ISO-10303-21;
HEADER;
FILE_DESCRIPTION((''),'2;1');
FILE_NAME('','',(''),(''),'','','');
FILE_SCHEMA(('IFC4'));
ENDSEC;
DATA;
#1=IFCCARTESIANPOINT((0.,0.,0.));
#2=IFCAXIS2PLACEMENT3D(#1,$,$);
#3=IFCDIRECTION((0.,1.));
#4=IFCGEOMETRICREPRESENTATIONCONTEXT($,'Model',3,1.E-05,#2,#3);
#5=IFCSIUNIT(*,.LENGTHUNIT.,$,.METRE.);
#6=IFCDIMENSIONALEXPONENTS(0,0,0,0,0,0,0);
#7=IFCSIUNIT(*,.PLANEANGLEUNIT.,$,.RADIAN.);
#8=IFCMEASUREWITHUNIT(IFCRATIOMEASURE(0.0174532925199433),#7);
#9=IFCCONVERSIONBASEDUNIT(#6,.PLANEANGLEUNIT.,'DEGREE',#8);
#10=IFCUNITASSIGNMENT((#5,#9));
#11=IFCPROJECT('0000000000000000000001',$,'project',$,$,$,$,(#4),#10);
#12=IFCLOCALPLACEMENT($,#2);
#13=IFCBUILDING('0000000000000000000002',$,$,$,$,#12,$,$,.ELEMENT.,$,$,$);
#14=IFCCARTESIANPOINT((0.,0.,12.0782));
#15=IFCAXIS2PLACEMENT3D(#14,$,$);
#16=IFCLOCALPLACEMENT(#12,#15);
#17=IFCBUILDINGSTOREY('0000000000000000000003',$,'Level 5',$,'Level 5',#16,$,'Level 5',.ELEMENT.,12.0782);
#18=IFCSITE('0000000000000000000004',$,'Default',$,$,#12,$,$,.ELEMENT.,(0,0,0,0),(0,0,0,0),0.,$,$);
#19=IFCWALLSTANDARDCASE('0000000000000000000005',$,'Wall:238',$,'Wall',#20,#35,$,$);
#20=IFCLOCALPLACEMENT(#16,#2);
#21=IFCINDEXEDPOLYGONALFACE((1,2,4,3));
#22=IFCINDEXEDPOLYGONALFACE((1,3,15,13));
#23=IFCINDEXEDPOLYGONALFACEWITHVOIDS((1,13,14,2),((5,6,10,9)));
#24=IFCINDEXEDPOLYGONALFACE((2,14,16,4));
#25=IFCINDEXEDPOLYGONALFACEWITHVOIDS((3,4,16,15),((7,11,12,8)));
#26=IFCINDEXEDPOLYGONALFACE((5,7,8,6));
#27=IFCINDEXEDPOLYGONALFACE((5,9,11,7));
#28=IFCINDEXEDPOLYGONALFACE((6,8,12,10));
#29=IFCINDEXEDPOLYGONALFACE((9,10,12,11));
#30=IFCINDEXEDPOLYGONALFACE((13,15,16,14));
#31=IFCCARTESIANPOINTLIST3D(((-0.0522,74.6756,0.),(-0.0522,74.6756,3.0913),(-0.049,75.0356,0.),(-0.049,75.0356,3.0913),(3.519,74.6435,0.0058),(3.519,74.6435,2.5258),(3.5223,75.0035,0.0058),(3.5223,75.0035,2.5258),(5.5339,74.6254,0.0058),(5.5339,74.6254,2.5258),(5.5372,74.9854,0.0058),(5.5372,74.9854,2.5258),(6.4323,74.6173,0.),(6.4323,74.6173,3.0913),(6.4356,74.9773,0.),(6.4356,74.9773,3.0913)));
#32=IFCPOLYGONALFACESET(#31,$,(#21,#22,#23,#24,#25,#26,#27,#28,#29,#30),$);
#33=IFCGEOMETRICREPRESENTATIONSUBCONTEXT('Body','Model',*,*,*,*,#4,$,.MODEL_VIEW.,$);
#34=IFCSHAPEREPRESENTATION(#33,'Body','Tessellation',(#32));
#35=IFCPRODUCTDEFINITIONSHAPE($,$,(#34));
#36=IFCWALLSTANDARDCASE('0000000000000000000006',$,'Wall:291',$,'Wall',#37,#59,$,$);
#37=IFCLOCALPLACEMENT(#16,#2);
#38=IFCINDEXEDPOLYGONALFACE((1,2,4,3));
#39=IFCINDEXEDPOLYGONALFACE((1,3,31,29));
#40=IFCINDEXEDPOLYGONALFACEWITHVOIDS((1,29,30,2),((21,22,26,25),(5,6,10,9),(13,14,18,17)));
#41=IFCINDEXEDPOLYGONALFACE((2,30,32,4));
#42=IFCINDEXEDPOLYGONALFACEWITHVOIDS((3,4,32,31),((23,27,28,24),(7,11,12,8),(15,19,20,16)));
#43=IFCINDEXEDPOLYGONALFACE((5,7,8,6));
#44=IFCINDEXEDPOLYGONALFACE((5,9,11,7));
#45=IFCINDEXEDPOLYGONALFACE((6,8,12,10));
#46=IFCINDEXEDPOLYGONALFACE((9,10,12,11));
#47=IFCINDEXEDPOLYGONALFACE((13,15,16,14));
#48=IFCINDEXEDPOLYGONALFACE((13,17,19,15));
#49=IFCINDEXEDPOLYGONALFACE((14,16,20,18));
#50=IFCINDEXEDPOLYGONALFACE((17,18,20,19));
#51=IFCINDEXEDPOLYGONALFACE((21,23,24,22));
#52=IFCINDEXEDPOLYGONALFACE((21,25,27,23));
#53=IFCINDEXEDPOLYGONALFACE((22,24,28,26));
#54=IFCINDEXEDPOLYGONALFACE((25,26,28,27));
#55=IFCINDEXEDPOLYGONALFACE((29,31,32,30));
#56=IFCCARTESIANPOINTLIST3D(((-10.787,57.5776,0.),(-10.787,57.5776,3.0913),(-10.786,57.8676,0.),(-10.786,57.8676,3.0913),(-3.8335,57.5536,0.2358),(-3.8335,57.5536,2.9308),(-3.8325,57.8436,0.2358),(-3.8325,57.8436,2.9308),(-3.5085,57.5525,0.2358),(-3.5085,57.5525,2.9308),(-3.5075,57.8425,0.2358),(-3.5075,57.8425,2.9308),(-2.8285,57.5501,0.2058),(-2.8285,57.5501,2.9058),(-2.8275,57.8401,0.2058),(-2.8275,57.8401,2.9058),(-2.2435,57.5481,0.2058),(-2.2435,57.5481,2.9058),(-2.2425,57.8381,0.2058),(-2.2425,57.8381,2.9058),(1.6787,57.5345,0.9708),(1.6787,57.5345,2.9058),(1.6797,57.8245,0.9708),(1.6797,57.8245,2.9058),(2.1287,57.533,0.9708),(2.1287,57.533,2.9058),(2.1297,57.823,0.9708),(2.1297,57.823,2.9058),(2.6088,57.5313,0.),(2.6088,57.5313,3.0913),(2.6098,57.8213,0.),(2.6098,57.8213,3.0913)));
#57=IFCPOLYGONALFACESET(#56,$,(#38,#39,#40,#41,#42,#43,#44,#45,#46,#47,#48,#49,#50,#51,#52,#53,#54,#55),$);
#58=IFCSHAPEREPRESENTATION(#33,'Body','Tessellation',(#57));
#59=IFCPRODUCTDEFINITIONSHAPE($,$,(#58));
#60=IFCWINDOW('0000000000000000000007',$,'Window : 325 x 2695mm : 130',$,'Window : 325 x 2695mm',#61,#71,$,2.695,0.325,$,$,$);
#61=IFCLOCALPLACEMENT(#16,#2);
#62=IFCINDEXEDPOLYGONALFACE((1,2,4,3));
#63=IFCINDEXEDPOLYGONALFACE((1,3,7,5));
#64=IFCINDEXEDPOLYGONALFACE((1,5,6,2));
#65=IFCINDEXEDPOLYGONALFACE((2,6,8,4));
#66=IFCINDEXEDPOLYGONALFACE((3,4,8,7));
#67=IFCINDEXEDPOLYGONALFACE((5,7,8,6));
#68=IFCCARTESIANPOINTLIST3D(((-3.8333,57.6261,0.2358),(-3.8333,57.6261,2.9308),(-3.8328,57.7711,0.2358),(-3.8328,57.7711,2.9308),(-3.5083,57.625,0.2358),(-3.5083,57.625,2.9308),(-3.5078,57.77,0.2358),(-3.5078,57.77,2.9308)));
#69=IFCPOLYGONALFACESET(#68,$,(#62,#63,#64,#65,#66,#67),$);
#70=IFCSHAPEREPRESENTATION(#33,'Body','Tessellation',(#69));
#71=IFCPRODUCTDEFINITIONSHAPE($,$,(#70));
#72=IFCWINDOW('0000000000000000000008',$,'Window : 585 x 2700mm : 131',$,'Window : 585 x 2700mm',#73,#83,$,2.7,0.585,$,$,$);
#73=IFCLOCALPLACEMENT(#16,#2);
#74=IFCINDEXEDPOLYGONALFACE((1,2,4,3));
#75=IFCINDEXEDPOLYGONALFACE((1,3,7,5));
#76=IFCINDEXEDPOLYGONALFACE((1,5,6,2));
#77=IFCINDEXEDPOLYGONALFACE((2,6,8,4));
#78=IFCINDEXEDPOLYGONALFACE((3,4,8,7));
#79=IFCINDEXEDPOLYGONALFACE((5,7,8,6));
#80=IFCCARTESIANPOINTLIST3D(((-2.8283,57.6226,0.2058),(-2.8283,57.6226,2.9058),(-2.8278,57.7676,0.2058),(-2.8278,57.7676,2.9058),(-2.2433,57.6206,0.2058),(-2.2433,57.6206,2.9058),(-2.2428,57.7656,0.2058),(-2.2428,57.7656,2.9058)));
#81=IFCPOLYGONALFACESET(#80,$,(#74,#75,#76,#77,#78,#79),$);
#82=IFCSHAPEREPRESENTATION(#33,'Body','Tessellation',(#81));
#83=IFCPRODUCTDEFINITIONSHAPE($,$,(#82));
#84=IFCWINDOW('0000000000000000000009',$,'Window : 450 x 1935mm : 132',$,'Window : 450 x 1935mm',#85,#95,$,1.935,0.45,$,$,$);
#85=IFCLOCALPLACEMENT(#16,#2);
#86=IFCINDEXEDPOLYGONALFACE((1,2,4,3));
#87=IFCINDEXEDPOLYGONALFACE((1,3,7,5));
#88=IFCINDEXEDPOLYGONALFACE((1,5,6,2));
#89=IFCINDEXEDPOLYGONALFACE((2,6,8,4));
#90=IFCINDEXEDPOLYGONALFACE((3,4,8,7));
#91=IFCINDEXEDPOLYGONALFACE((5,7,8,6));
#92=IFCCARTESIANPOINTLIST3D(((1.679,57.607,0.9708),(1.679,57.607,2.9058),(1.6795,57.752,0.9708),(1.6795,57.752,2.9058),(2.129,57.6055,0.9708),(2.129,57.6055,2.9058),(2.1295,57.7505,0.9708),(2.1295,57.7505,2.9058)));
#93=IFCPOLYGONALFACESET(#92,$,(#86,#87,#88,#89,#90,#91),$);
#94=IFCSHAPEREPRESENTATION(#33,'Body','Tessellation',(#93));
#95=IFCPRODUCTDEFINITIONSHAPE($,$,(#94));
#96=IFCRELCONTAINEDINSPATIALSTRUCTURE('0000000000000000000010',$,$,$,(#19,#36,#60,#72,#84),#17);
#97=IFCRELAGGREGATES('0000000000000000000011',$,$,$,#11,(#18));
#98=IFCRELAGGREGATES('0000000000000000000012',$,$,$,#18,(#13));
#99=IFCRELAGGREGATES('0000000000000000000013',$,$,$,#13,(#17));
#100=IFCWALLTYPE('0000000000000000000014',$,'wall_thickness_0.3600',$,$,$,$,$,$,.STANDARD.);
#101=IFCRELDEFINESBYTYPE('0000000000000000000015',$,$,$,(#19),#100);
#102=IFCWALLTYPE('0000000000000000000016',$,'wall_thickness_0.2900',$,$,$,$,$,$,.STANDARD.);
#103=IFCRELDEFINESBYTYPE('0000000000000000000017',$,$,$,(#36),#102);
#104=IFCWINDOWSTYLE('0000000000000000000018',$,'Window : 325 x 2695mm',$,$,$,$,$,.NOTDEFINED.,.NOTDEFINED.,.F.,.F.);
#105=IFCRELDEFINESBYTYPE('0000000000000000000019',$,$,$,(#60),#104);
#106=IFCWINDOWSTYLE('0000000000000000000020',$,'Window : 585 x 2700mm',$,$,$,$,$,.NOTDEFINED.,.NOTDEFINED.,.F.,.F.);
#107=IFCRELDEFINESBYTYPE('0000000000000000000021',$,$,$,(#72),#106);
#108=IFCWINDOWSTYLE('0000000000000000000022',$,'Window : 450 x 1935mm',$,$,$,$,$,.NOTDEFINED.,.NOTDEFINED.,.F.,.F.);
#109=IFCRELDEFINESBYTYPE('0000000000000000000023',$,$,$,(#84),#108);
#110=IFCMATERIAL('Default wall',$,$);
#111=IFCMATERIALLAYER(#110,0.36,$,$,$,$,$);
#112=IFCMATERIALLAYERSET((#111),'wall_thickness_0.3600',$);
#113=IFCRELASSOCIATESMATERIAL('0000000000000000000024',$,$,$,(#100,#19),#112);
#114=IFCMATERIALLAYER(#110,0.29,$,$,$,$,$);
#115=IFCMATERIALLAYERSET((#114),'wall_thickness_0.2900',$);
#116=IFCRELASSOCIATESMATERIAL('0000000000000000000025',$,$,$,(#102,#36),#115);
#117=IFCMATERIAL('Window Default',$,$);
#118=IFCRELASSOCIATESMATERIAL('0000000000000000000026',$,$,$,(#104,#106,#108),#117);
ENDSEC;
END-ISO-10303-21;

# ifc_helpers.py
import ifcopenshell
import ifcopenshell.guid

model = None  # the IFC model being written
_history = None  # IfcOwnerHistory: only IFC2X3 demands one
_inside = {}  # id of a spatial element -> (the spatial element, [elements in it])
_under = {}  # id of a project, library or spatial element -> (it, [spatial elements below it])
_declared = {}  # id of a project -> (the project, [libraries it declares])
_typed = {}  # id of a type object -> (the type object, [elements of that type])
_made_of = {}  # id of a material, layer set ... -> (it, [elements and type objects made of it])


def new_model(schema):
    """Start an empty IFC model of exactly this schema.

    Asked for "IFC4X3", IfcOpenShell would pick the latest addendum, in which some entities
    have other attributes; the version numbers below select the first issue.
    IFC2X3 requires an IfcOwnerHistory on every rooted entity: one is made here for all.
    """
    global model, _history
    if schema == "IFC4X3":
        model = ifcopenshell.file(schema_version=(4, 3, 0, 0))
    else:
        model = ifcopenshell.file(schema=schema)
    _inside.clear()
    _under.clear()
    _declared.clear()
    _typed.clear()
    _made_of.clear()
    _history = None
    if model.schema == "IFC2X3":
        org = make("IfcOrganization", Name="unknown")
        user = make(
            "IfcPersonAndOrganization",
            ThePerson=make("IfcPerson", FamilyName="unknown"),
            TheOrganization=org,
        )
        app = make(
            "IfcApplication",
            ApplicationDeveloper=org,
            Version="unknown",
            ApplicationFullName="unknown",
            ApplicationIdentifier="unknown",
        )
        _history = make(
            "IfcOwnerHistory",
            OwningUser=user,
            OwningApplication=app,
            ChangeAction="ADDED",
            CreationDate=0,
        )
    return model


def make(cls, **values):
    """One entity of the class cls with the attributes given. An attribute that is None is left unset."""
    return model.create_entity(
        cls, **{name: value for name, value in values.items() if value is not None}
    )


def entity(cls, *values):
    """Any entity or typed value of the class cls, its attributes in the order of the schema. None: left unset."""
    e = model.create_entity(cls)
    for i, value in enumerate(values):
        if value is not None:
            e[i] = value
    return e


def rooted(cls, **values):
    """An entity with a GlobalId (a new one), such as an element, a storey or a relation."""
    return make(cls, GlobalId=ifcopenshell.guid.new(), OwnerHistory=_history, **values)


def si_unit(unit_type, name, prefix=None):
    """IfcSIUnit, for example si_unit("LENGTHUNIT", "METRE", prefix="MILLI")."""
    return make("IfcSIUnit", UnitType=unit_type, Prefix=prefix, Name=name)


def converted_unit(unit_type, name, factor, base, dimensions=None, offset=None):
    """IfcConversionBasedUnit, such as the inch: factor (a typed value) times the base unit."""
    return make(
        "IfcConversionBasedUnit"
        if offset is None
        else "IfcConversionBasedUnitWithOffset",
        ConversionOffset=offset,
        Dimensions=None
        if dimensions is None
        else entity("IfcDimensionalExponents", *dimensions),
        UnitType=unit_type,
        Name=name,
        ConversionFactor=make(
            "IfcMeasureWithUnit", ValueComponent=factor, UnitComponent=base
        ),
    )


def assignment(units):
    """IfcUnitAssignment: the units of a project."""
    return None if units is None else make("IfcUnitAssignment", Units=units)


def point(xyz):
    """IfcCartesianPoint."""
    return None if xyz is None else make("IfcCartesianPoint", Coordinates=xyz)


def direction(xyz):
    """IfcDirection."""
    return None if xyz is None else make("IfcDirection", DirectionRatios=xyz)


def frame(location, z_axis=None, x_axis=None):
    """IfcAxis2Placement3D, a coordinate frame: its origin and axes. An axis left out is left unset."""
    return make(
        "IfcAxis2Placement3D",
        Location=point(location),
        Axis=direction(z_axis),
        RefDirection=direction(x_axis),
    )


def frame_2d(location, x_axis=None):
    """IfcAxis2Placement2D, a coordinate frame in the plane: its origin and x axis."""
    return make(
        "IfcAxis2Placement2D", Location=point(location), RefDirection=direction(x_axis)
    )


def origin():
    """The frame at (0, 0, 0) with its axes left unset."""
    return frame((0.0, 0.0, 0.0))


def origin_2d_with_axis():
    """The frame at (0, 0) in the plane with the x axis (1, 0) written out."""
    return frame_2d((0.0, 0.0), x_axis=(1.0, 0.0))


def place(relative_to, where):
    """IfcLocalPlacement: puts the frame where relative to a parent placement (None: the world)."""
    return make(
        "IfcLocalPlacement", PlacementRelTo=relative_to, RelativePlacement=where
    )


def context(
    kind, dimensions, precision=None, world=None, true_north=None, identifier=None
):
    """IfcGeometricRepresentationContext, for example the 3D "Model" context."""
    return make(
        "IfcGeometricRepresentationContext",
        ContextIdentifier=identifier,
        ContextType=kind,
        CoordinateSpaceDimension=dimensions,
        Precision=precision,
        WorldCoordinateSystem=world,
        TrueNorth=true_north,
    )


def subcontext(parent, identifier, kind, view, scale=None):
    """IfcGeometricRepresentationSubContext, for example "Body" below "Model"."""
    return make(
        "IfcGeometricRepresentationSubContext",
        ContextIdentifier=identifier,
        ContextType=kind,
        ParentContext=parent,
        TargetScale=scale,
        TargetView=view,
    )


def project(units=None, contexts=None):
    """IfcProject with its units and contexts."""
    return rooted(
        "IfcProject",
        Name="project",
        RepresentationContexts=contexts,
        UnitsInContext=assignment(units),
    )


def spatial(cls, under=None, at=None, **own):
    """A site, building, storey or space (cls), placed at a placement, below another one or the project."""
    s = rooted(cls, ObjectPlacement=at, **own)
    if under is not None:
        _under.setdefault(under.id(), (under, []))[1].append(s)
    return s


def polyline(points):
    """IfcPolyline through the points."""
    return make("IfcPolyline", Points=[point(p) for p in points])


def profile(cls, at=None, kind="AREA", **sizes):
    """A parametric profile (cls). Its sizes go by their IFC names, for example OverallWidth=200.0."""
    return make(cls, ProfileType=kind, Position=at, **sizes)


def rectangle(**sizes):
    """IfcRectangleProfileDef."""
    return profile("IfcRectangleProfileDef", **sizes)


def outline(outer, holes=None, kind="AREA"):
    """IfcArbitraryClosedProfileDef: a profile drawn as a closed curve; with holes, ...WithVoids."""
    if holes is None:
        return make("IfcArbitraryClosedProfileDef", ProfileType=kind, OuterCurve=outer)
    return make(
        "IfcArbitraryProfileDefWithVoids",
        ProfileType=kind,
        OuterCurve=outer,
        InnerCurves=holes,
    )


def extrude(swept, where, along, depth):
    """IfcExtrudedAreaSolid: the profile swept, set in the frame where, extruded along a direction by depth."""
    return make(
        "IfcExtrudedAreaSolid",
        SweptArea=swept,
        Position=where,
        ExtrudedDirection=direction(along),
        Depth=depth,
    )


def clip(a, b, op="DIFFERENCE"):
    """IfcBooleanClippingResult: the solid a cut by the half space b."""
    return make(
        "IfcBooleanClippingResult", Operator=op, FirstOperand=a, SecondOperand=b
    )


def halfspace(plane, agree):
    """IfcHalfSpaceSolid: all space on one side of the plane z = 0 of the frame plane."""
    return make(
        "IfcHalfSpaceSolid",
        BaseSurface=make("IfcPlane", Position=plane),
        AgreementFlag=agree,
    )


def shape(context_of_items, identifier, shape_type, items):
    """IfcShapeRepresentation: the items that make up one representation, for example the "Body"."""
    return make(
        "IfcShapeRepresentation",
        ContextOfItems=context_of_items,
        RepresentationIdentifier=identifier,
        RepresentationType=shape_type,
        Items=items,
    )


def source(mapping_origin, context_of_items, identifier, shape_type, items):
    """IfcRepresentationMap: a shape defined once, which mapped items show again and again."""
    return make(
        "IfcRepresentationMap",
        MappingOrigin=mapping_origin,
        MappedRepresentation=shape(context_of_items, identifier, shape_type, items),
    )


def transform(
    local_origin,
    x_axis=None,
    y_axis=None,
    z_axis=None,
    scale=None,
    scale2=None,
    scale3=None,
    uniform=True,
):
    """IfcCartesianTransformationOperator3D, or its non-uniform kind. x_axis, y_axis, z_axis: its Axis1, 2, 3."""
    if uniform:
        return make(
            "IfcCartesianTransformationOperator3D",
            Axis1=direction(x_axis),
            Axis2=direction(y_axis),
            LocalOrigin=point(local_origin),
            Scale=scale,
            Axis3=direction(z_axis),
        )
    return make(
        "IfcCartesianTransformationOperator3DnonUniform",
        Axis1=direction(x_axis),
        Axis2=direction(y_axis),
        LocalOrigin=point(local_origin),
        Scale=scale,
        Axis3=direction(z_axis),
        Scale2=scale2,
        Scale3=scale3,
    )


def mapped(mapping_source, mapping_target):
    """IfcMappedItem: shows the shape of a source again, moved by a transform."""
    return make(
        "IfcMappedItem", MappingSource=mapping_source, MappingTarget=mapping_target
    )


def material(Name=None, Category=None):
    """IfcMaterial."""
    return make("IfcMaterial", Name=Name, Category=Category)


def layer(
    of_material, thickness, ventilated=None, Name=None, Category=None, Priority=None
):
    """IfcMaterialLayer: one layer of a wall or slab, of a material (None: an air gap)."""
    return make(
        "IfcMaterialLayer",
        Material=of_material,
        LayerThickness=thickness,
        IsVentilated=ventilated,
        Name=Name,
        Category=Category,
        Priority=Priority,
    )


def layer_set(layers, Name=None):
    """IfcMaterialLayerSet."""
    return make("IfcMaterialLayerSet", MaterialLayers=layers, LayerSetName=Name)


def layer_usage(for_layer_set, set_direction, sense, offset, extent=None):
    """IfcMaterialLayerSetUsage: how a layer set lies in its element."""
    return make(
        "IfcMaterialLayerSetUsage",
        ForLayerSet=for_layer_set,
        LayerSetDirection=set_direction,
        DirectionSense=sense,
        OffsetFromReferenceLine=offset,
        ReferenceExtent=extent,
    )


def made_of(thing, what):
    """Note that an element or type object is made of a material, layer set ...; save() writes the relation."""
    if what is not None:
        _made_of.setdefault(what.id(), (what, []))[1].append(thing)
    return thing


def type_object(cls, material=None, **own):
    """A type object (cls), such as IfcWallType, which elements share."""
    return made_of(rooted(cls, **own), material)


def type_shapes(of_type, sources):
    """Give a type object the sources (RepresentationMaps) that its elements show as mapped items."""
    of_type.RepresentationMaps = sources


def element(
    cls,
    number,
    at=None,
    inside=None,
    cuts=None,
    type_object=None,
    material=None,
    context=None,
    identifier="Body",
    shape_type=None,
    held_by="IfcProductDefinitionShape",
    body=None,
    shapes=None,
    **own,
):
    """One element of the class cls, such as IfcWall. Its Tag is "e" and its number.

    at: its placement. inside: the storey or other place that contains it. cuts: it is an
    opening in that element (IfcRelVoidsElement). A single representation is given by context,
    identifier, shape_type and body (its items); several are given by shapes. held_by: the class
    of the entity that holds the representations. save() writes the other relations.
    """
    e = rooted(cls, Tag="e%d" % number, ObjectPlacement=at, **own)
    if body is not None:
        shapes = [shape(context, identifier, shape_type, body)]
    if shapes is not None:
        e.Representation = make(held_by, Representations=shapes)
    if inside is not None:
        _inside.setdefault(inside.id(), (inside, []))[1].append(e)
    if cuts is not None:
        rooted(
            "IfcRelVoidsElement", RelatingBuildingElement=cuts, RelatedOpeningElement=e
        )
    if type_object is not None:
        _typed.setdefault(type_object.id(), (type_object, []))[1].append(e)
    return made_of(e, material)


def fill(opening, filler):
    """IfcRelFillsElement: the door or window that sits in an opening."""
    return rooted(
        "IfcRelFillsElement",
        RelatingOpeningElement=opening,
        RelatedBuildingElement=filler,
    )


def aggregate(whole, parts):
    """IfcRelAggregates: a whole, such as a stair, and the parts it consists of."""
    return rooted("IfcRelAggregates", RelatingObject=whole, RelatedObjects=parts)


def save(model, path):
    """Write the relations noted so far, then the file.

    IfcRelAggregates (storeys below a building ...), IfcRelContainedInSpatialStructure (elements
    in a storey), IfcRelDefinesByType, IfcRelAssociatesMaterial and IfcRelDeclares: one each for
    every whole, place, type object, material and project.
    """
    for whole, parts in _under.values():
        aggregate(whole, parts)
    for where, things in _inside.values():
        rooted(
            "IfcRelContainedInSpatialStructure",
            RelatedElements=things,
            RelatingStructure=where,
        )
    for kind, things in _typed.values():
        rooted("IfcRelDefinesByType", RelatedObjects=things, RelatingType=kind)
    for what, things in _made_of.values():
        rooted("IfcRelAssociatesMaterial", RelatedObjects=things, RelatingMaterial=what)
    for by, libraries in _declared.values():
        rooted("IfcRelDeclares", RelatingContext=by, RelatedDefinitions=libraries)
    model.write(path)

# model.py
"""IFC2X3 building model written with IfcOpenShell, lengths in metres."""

from ifc_helpers import new_model, entity, si_unit, converted_unit, direction, frame, frame_2d, origin, origin_2d_with_axis, place, context, subcontext, project, spatial, polyline, rectangle, outline, extrude, clip, halfspace, source, transform, mapped, material, layer, layer_set, layer_usage, type_object, type_shapes, element, fill, save


model = new_model("IFC2X3")

# Units and contexts
model_context = context("Model", 3, precision=1e-05, world=origin(), true_north=direction((0.0, 1.0)))
body_context = subcontext(model_context, "Body", "Model", "MODEL_VIEW")
ifc_project = project(units=[si_unit("LENGTHUNIT", "METRE"), converted_unit("PLANEANGLEUNIT", "DEGREE", entity("IfcRatioMeasure", 0.0174532925199433), si_unit("PLANEANGLEUNIT", "RADIAN"), dimensions=[0, 0, 0, 0, 0, 0, 0])], contexts=[model_context])

# Site, building, storey
placement_1 = place(None, origin())
site = spatial("IfcSite", under=ifc_project, at=placement_1, Name="Default", CompositionType="ELEMENT", RefLatitude=(0, 0, 0, 0), RefLongitude=(0, 0, 0, 0), RefElevation=0.0)
building = spatial("IfcBuilding", under=site, at=placement_1, CompositionType="ELEMENT")
storey_placement = place(placement_1, frame((0.0, 0.0, 12.0782)))
storey = spatial("IfcBuildingStorey", under=building, at=storey_placement, Name="Level 5", ObjectType="Level 5", LongName="Level 5", CompositionType="ELEMENT", Elevation=12.0782)

# Shared definitions
ifc_material_1 = material(Name="Default wall")

# Shared definitions
ifc_layer_1 = layer(ifc_material_1, 0.36)
ifc_layer_set_1 = layer_set([ifc_layer_1], Name="wall_thickness_0.3600")
ifc_layer_usage_1 = layer_usage(ifc_layer_set_1, "AXIS2", "POSITIVE", -0.18)
wall_type_1 = type_object("IfcWallType", Name="wall_thickness_0.3600", PredefinedType="STANDARD", material=ifc_layer_set_1)
ifc_material_2 = material(Name="Window Default")

# Wall, opening
wall_1_placement = place(storey_placement, frame((-0.0506, 74.8556, 0.0), z_axis=(0.0, 0.0, 1.0), x_axis=(0.99996, -0.008993, 0.0)))
wall_1 = element("IfcWallStandardCase", 1, at=wall_1_placement, inside=storey, type_object=wall_type_1, material=ifc_layer_usage_1, Name="Wall:238", ObjectType="Wall", context=body_context, shape_type="Clipping", body=[
    clip(extrude(outline(polyline([(6.4848, -0.18), (6.4848, 0.18), (0.0, 0.18), (0.0, -0.18), (6.4848, -0.18)])), origin(), (0.0, 0.0, 1.0), 3.0913), halfspace(frame((13.6125, 3.7855, 5.7734), z_axis=(-0.003713, 0.39562, 0.918407), x_axis=(-0.999956, -0.009385, 0.0)), False)),
])
opening_1_placement = place(wall_1_placement, frame((3.5714, -0.18, 0.0058)))
element("IfcOpeningElement", 2, at=opening_1_placement, cuts=wall_1, ObjectType="Opening", context=body_context, shape_type="SweptSolid", body=[
    extrude(rectangle(XDim=2.015, YDim=2.52, at=frame_2d((1.26, 1.0075), x_axis=(0.0, 1.0))), frame((0.0, 0.0, 0.0), z_axis=(0.0, 1.0, 0.0), x_axis=(0.0, 0.0, 1.0)), (0.0, 0.0, 1.0), 0.36),
])

# Wall, openings, windows
ifc_layer_2 = layer(ifc_material_1, 0.29)
ifc_layer_set_2 = layer_set([ifc_layer_2], Name="wall_thickness_0.2900")
ifc_layer_usage_2 = layer_usage(ifc_layer_set_2, "AXIS2", "POSITIVE", -0.145)
wall_type_2 = type_object("IfcWallType", Name="wall_thickness_0.2900", PredefinedType="STANDARD", material=ifc_layer_set_2)
wall_2_placement = place(storey_placement, frame((-10.7865, 57.7226, 0.0), z_axis=(0.0, 0.0, 1.0), x_axis=(0.999994, -0.00346, 0.0)))
wall_2 = element("IfcWallStandardCase", 3, at=wall_2_placement, inside=storey, type_object=wall_type_2, material=ifc_layer_usage_2, Name="Wall:291", ObjectType="Wall", context=body_context, shape_type="Clipping", body=[
    clip(extrude(outline(polyline([(13.3959, -0.145), (13.3959, 0.145), (0.0, 0.145), (0.0, -0.145), (13.3959, -0.145)])), origin(), (0.0, 0.0, 1.0), 3.0913), halfspace(frame((-1.9669, 0.0778, 9.0175), z_axis=(-0.002535, -0.391122, 0.920336), x_axis=(0.999989, -0.00469, 0.000761)), False)),
])
opening_2_placement = place(wall_2_placement, frame((6.9535, -0.145, 0.2358)))
opening_2 = element("IfcOpeningElement", 4, at=opening_2_placement, cuts=wall_2, ObjectType="Opening", context=body_context, shape_type="SweptSolid", body=[
    extrude(rectangle(XDim=0.325, YDim=2.695, at=frame_2d((1.3475, 0.1625), x_axis=(0.0, 1.0))), frame((0.0, 0.0, 0.0), z_axis=(0.0, 1.0, 0.0), x_axis=(0.0, 0.0, 1.0)), (0.0, 0.0, 1.0), 0.29),
])
opening_3_placement = place(wall_2_placement, frame((7.9585, -0.145, 0.2058)))
opening_3 = element("IfcOpeningElement", 5, at=opening_3_placement, cuts=wall_2, ObjectType="Opening", context=body_context, shape_type="SweptSolid", body=[
    extrude(rectangle(XDim=0.585, YDim=2.7, at=frame_2d((1.35, 0.2925), x_axis=(0.0, 1.0))), frame((0.0, 0.0, 0.0), z_axis=(0.0, 1.0, 0.0), x_axis=(0.0, 0.0, 1.0)), (0.0, 0.0, 1.0), 0.29),
])
opening_4_placement = place(wall_2_placement, frame((12.4658, -0.145, 0.9708)))
opening_4 = element("IfcOpeningElement", 6, at=opening_4_placement, cuts=wall_2, ObjectType="Opening", context=body_context, shape_type="SweptSolid", body=[
    extrude(rectangle(XDim=0.45, YDim=1.935, at=frame_2d((0.9675, 0.225), x_axis=(0.0, 1.0))), frame((0.0, 0.0, 0.0), z_axis=(0.0, 1.0, 0.0), x_axis=(0.0, 0.0, 1.0)), (0.0, 0.0, 1.0), 0.29),
])
window_style_1 = type_object("IfcWindowStyle", Name="Window : 325 x 2695mm", ConstructionType="NOTDEFINED", OperationType="NOTDEFINED", ParameterTakesPrecedence=False, Sizeable=False, material=ifc_material_2)
shared_shape_1 = source(origin(), body_context, "Body", "SweptSolid", [
    extrude(rectangle(XDim=0.145, YDim=0.325, at=origin_2d_with_axis()), frame((0.1625, 0.145, 0.0), z_axis=(0.0, 0.0, 1.0), x_axis=(0.0, 1.0, 0.0)), (0.0, 0.0, 1.0), 2.695),
])
type_shapes(window_style_1, [shared_shape_1])
window_1_placement = place(opening_2_placement, origin())
window_1 = element("IfcWindow", 7, at=window_1_placement, inside=storey, type_object=window_style_1, Name="Window : 325 x 2695mm : 130", ObjectType="Window : 325 x 2695mm", OverallHeight=2.695, OverallWidth=0.325, context=body_context, shape_type="MappedRepresentation", body=[
    mapped(shared_shape_1, transform((0.0, 0.0, 0.0), scale=1.0)),
])
fill(opening_2, window_1)
window_style_2 = type_object("IfcWindowStyle", Name="Window : 585 x 2700mm", ConstructionType="NOTDEFINED", OperationType="NOTDEFINED", ParameterTakesPrecedence=False, Sizeable=False, material=ifc_material_2)
shared_shape_2 = source(origin(), body_context, "Body", "SweptSolid", [
    extrude(rectangle(XDim=0.145, YDim=0.585, at=origin_2d_with_axis()), frame((0.2925, 0.145, 0.0), z_axis=(0.0, 0.0, 1.0), x_axis=(0.0, 1.0, 0.0)), (0.0, 0.0, 1.0), 2.7),
])
type_shapes(window_style_2, [shared_shape_2])
window_2_placement = place(opening_3_placement, origin())
window_2 = element("IfcWindow", 8, at=window_2_placement, inside=storey, type_object=window_style_2, Name="Window : 585 x 2700mm : 131", ObjectType="Window : 585 x 2700mm", OverallHeight=2.7, OverallWidth=0.585, context=body_context, shape_type="MappedRepresentation", body=[
    mapped(shared_shape_2, transform((0.0, 0.0, 0.0), scale=1.0)),
])
fill(opening_3, window_2)
window_style_3 = type_object("IfcWindowStyle", Name="Window : 450 x 1935mm", ConstructionType="NOTDEFINED", OperationType="NOTDEFINED", ParameterTakesPrecedence=False, Sizeable=False, material=ifc_material_2)
shared_shape_3 = source(origin(), body_context, "Body", "SweptSolid", [
    extrude(rectangle(XDim=0.145, YDim=0.45, at=origin_2d_with_axis()), frame((0.225, 0.145, 0.0), z_axis=(0.0, 0.0, 1.0), x_axis=(0.0, 1.0, 0.0)), (0.0, 0.0, 1.0), 1.935),
])
type_shapes(window_style_3, [shared_shape_3])
window_3_placement = place(opening_4_placement, origin())
window_3 = element("IfcWindow", 9, at=window_3_placement, inside=storey, type_object=window_style_3, Name="Window : 450 x 1935mm : 132", ObjectType="Window : 450 x 1935mm", OverallHeight=1.935, OverallWidth=0.45, context=body_context, shape_type="MappedRepresentation", body=[
    mapped(shared_shape_3, transform((0.0, 0.0, 0.0), scale=1.0)),
])
fill(opening_4, window_3)

save(model, "model.ifc")
